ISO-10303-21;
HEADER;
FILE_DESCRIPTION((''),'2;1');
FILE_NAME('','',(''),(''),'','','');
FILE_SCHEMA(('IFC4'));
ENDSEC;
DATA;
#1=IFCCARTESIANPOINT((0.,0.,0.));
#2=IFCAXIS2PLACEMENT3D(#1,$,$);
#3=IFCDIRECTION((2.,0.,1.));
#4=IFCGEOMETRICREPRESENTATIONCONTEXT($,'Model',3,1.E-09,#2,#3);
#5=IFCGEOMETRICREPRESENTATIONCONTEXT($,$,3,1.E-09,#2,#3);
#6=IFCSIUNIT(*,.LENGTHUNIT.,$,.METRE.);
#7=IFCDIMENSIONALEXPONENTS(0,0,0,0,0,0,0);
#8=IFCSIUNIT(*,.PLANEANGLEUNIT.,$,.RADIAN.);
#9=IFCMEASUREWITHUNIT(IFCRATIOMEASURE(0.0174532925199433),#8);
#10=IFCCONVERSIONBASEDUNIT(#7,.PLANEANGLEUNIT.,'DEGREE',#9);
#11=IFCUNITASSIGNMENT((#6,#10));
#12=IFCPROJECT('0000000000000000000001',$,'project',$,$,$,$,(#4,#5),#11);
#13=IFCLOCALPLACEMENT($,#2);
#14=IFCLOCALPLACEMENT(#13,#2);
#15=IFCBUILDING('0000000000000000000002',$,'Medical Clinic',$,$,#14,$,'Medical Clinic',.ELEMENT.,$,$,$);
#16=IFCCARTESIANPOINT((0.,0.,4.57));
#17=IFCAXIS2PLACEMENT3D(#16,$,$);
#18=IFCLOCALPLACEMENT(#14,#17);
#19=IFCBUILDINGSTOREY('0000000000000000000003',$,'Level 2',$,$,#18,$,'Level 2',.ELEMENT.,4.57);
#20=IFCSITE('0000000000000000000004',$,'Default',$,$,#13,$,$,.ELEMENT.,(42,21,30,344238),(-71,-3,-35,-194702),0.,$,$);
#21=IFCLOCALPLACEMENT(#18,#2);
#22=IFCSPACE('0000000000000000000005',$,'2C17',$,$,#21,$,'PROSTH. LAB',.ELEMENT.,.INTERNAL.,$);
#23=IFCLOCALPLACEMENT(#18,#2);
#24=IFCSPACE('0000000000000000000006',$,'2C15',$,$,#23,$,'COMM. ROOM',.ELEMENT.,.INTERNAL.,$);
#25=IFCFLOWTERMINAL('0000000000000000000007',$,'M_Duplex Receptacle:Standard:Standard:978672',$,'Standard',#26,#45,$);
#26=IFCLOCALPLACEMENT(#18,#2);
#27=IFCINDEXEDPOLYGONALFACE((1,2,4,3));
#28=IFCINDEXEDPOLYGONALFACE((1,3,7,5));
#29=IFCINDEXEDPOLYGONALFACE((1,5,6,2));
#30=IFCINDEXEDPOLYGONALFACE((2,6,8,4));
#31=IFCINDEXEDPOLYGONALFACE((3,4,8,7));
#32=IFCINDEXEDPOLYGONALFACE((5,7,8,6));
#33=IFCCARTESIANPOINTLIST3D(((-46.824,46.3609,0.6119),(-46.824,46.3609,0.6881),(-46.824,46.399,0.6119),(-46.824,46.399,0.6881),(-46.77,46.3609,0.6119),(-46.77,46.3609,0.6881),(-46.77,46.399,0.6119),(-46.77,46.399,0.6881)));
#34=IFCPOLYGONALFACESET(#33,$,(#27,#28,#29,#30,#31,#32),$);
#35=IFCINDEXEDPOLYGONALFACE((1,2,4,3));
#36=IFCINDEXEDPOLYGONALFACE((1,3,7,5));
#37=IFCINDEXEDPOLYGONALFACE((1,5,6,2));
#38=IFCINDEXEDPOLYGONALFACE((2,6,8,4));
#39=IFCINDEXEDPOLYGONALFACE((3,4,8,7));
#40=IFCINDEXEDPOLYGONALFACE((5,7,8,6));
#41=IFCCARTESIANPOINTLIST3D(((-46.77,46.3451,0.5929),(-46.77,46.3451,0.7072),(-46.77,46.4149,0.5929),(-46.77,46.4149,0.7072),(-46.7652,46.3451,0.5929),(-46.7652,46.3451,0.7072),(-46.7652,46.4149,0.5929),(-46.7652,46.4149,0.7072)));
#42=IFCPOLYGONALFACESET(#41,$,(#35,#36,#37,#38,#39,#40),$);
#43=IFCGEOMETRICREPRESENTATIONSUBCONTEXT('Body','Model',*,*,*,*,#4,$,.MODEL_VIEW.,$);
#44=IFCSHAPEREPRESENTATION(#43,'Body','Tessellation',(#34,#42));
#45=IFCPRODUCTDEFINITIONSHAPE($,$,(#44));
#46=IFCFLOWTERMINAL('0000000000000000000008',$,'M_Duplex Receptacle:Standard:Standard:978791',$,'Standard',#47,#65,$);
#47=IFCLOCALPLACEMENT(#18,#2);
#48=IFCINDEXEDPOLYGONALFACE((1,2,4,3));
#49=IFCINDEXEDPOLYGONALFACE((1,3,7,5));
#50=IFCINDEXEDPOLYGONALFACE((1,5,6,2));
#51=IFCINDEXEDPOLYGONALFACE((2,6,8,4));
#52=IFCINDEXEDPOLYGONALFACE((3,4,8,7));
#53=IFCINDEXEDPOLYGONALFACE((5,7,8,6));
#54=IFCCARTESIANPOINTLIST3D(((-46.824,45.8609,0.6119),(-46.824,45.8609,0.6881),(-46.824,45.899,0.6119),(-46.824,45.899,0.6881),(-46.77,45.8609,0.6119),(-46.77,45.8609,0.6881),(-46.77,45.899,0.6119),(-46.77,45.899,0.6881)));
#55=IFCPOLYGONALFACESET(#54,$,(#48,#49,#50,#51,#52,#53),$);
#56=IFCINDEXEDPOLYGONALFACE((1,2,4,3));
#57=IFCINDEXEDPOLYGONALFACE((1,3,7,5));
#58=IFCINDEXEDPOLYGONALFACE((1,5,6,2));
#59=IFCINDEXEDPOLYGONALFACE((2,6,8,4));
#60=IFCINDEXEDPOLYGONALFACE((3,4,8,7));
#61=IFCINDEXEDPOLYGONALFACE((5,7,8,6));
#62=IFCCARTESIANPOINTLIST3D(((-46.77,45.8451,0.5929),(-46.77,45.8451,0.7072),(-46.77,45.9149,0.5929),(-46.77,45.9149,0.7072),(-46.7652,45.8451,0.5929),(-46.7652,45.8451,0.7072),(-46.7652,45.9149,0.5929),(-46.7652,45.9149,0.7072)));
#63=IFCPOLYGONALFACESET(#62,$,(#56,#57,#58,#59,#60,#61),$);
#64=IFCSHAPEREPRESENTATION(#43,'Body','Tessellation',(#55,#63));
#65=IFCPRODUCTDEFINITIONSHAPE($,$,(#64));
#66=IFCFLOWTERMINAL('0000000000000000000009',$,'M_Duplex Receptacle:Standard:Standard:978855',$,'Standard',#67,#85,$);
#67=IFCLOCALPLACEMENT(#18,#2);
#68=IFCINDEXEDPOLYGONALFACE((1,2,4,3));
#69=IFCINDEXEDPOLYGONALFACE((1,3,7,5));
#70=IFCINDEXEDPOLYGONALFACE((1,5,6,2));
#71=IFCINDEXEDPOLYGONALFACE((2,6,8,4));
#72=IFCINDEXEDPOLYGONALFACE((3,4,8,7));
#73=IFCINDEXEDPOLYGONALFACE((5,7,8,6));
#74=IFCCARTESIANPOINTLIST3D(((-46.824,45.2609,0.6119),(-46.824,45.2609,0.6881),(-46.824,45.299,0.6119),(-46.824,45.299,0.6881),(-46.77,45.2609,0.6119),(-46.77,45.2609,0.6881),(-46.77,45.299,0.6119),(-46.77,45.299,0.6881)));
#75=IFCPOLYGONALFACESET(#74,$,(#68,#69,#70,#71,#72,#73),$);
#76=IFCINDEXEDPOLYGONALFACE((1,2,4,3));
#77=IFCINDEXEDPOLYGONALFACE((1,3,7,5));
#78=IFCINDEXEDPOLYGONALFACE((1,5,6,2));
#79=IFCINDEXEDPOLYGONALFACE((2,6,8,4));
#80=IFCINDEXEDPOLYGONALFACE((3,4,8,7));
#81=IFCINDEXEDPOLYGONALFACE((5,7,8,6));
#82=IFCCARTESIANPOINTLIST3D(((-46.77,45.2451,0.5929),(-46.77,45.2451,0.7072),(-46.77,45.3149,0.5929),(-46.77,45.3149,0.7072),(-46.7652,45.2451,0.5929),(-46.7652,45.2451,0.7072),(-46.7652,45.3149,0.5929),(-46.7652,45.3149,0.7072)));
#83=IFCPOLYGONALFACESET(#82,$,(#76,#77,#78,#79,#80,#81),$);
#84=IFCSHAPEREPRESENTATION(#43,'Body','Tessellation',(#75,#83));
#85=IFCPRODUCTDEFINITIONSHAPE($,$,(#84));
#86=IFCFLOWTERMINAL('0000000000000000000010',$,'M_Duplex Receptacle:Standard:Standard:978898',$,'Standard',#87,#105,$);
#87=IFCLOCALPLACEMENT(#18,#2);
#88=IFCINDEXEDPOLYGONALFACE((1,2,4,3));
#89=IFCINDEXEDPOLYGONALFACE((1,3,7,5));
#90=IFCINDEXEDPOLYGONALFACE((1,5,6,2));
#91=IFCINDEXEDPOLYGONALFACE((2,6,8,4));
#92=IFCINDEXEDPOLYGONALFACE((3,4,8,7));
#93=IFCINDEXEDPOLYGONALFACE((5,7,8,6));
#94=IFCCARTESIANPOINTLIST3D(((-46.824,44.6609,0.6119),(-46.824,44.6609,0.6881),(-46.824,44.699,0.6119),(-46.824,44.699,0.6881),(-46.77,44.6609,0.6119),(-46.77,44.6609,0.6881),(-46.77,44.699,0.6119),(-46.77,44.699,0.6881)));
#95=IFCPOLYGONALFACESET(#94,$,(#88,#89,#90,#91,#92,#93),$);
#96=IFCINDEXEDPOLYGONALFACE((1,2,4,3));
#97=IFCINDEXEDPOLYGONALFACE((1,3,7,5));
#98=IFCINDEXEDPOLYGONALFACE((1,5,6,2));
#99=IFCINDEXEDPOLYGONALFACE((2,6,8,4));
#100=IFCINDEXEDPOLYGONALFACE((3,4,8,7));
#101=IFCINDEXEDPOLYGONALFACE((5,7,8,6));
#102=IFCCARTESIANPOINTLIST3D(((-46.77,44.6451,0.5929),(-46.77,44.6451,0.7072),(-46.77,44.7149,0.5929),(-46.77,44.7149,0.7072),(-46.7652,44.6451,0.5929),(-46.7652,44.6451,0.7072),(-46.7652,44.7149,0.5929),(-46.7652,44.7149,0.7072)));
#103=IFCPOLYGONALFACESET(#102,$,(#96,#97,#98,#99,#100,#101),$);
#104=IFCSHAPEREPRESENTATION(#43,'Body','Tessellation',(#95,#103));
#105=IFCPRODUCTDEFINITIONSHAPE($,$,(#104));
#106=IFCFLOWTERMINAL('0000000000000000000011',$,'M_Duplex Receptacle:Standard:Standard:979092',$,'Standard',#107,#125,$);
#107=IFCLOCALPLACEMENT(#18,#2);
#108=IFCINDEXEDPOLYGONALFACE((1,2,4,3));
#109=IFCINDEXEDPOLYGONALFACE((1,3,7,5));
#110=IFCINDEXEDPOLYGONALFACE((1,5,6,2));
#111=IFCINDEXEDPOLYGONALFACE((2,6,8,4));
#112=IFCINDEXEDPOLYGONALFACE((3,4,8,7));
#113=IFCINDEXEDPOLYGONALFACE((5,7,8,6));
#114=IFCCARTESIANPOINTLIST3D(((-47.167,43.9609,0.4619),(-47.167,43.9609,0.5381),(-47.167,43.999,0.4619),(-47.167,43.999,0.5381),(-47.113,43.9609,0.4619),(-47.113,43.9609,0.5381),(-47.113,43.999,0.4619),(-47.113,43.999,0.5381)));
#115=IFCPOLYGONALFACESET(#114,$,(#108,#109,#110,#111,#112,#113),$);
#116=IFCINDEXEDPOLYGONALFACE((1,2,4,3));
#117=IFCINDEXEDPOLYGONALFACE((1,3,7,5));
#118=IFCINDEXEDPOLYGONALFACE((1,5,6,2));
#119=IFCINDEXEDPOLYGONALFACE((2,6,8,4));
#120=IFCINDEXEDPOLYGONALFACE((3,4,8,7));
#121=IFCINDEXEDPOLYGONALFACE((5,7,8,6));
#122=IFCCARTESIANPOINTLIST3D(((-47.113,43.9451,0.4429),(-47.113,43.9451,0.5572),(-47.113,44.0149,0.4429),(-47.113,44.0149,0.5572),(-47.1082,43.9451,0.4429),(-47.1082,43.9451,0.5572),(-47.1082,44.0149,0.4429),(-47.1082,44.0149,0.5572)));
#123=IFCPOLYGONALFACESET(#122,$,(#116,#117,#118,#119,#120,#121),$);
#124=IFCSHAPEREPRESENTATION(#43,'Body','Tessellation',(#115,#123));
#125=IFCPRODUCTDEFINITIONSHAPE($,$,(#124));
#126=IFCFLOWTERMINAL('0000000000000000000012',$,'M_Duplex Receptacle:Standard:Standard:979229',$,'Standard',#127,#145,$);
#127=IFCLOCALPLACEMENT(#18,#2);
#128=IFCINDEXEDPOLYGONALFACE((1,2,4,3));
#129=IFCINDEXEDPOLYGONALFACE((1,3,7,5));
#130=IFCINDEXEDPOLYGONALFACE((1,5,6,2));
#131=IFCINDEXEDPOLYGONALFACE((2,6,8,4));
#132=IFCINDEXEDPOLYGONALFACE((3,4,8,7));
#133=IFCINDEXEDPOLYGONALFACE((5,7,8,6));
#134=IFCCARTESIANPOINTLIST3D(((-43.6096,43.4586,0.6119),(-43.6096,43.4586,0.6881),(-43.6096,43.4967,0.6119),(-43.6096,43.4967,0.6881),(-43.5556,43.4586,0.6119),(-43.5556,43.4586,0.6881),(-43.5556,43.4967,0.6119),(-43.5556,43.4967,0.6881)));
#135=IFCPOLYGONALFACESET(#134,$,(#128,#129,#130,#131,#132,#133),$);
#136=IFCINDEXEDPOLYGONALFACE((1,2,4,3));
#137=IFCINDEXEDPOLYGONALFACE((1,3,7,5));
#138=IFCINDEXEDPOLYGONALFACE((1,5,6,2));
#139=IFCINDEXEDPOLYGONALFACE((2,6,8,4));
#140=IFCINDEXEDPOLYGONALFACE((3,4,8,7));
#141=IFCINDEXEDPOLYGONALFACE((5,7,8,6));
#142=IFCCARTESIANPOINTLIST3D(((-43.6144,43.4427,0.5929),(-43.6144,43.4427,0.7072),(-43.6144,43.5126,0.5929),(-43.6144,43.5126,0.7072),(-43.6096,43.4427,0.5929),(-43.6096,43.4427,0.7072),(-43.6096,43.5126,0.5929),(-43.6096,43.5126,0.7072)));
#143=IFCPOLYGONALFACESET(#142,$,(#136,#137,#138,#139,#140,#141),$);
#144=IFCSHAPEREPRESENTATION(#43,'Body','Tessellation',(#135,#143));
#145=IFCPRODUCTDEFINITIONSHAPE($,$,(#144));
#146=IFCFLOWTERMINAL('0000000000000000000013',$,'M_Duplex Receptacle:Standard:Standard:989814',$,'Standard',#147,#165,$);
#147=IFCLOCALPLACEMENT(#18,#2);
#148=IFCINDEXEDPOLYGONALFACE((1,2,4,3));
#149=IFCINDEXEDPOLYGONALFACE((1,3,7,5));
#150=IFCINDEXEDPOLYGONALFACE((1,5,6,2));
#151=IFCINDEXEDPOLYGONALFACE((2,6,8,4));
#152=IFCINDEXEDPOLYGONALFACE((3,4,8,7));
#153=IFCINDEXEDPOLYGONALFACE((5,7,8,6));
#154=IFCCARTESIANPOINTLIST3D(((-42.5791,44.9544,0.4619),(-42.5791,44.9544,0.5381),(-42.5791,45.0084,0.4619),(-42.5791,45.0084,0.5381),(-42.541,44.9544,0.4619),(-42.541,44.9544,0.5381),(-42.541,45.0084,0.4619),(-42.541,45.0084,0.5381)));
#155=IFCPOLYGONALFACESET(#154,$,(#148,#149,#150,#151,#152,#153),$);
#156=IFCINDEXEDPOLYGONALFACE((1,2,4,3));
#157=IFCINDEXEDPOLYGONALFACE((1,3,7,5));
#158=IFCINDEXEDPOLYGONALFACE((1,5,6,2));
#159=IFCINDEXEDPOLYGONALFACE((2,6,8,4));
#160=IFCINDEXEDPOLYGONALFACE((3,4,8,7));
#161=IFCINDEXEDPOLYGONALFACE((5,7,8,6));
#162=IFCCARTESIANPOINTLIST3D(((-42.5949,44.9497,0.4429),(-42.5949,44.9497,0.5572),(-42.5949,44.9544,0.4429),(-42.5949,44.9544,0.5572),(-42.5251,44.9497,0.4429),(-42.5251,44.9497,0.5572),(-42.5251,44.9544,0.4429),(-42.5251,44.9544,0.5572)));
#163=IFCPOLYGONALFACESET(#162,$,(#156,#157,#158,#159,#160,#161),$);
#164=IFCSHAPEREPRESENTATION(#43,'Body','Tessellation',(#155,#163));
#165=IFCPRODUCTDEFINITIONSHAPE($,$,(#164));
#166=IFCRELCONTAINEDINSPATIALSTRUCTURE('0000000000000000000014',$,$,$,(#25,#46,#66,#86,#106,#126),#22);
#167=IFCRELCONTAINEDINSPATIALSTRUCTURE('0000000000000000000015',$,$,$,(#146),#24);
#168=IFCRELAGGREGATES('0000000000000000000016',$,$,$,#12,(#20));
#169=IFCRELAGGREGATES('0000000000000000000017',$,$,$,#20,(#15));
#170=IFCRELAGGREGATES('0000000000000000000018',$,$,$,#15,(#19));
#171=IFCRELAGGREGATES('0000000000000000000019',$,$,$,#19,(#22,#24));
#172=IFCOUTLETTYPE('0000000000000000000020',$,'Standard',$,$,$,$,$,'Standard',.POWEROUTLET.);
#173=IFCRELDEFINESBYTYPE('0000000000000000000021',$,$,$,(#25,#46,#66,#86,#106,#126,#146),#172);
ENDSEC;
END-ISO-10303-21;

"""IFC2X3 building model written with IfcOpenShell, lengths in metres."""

from ifc_helpers import new_model, entity, si_unit, converted_unit, direction, frame, frame_2d, origin, origin_2d_with_axis, place, context, subcontext, project, spatial, rectangle, extrude, source, transform, mapped, type_object, type_shapes, element, save


model = new_model("IFC2X3")

# Units and contexts
model_context = context("Model", 3, precision=1e-09, world=origin(), true_north=direction((2.0, 0.0, 1.0)))
context_of_model = context(None, 3, precision=1e-09, world=origin(), true_north=direction((2.0, 0.0, 1.0)))
body_context = subcontext(model_context, "Body", "Model", "MODEL_VIEW")
ifc_project = project(units=[si_unit("LENGTHUNIT", "METRE"), converted_unit("PLANEANGLEUNIT", "DEGREE", entity("IfcRatioMeasure", 0.0174532925199433), si_unit("PLANEANGLEUNIT", "RADIAN"), dimensions=[0, 0, 0, 0, 0, 0, 0])], contexts=[model_context, context_of_model])

# Site, building, storey
site_placement = place(None, origin())
site = spatial("IfcSite", under=ifc_project, at=site_placement, Name="Default", CompositionType="ELEMENT", RefLatitude=(42, 21, 30, 344238), RefLongitude=(-71, -3, -35, -194702), RefElevation=0.0)
building_placement = place(site_placement, origin())
building = spatial("IfcBuilding", under=site, at=building_placement, Name="Medical Clinic", LongName="Medical Clinic", CompositionType="ELEMENT")
storey_placement = place(building_placement, frame((0.0, 0.0, 4.57)))
storey = spatial("IfcBuildingStorey", under=building, at=storey_placement, Name="Level 2", LongName="Level 2", CompositionType="ELEMENT", Elevation=4.57)

# Shared definitions
space_1_placement = place(storey_placement, origin())
space_1 = spatial("IfcSpace", under=storey, at=space_1_placement, Name="2C17", LongName="PROSTH. LAB", CompositionType="ELEMENT", InteriorOrExteriorSpace="INTERNAL")

# Shared definitions
space_2_placement = place(storey_placement, origin())
space_2 = spatial("IfcSpace", under=storey, at=space_2_placement, Name="2C15", LongName="COMM. ROOM", CompositionType="ELEMENT", InteriorOrExteriorSpace="INTERNAL")

# Flow terminals
outlet_type = type_object("IfcOutletType", Name="Standard", ElementType="Standard", PredefinedType="POWEROUTLET")
shared_shape_1 = source(origin(), body_context, "Body", "SweptSolid", [
    extrude(rectangle(XDim=0.0381, YDim=0.0762, at=origin_2d_with_axis()), frame((0.0, 0.0, -0.054), z_axis=(0.0, 0.0, 1.0), x_axis=(-1.0, 0.0, 0.0)), (0.0, 0.0, 1.0), 0.054),
    extrude(rectangle(XDim=0.0698, YDim=0.1143, at=frame_2d((0.0, 0.0), x_axis=(1.0, 0.0))), frame((0.0, 0.0, 0.0), z_axis=(0.0, 0.0, 1.0), x_axis=(-1.0, 0.0, 0.0)), (0.0, 0.0, 1.0), 0.0048),
])
type_shapes(outlet_type, [shared_shape_1])
for number, where, z_axis, x_axis, name in (
    (1, (-46.77, 46.38, 0.65), (1.0, 0.0, 0.0), (0.0, 1.0, 0.0), "M_Duplex Receptacle:Standard:Standard:978672"),
    (2, (-46.77, 45.88, 0.65), (1.0, 0.0, 0.0), (0.0, 1.0, 0.0), "M_Duplex Receptacle:Standard:Standard:978791"),
    (3, (-46.77, 45.28, 0.65), (1.0, 0.0, 0.0), (0.0, 1.0, 0.0), "M_Duplex Receptacle:Standard:Standard:978855"),
    (4, (-46.77, 44.68, 0.65), (1.0, 0.0, 0.0), (0.0, 1.0, 0.0), "M_Duplex Receptacle:Standard:Standard:978898"),
    (5, (-47.113, 43.98, 0.5), (1.0, 0.0, 0.0), (0.0, 1.0, 0.0), "M_Duplex Receptacle:Standard:Standard:979092"),
    (6, (-43.6096, 43.4776, 0.65), (-1.0, 0.0, 0.0), (0.0, -1.0, 0.0), "M_Duplex Receptacle:Standard:Standard:979229"),
):
    element("IfcFlowTerminal", number, at=place(space_1_placement, frame(where, z_axis=z_axis, x_axis=x_axis)), inside=space_1, type_object=outlet_type, Name=name, ObjectType="Standard", context=body_context, shape_type="MappedRepresentation", body=[
        mapped(shared_shape_1, transform((0.0, 0.0, 0.0), scale=1.0)),
    ])
flow_terminal_1_placement = place(space_2_placement, frame((-42.56, 44.9544, 0.5), z_axis=(0.0, -1.0, 0.0), x_axis=(1.0, 0.0, 0.0)))
element("IfcFlowTerminal", 7, at=flow_terminal_1_placement, inside=space_2, type_object=outlet_type, Name="M_Duplex Receptacle:Standard:Standard:989814", ObjectType="Standard", context=body_context, shape_type="MappedRepresentation", body=[
    mapped(shared_shape_1, transform((0.0, 0.0, 0.0), scale=1.0)),
])

save(model, "model.ifc")
